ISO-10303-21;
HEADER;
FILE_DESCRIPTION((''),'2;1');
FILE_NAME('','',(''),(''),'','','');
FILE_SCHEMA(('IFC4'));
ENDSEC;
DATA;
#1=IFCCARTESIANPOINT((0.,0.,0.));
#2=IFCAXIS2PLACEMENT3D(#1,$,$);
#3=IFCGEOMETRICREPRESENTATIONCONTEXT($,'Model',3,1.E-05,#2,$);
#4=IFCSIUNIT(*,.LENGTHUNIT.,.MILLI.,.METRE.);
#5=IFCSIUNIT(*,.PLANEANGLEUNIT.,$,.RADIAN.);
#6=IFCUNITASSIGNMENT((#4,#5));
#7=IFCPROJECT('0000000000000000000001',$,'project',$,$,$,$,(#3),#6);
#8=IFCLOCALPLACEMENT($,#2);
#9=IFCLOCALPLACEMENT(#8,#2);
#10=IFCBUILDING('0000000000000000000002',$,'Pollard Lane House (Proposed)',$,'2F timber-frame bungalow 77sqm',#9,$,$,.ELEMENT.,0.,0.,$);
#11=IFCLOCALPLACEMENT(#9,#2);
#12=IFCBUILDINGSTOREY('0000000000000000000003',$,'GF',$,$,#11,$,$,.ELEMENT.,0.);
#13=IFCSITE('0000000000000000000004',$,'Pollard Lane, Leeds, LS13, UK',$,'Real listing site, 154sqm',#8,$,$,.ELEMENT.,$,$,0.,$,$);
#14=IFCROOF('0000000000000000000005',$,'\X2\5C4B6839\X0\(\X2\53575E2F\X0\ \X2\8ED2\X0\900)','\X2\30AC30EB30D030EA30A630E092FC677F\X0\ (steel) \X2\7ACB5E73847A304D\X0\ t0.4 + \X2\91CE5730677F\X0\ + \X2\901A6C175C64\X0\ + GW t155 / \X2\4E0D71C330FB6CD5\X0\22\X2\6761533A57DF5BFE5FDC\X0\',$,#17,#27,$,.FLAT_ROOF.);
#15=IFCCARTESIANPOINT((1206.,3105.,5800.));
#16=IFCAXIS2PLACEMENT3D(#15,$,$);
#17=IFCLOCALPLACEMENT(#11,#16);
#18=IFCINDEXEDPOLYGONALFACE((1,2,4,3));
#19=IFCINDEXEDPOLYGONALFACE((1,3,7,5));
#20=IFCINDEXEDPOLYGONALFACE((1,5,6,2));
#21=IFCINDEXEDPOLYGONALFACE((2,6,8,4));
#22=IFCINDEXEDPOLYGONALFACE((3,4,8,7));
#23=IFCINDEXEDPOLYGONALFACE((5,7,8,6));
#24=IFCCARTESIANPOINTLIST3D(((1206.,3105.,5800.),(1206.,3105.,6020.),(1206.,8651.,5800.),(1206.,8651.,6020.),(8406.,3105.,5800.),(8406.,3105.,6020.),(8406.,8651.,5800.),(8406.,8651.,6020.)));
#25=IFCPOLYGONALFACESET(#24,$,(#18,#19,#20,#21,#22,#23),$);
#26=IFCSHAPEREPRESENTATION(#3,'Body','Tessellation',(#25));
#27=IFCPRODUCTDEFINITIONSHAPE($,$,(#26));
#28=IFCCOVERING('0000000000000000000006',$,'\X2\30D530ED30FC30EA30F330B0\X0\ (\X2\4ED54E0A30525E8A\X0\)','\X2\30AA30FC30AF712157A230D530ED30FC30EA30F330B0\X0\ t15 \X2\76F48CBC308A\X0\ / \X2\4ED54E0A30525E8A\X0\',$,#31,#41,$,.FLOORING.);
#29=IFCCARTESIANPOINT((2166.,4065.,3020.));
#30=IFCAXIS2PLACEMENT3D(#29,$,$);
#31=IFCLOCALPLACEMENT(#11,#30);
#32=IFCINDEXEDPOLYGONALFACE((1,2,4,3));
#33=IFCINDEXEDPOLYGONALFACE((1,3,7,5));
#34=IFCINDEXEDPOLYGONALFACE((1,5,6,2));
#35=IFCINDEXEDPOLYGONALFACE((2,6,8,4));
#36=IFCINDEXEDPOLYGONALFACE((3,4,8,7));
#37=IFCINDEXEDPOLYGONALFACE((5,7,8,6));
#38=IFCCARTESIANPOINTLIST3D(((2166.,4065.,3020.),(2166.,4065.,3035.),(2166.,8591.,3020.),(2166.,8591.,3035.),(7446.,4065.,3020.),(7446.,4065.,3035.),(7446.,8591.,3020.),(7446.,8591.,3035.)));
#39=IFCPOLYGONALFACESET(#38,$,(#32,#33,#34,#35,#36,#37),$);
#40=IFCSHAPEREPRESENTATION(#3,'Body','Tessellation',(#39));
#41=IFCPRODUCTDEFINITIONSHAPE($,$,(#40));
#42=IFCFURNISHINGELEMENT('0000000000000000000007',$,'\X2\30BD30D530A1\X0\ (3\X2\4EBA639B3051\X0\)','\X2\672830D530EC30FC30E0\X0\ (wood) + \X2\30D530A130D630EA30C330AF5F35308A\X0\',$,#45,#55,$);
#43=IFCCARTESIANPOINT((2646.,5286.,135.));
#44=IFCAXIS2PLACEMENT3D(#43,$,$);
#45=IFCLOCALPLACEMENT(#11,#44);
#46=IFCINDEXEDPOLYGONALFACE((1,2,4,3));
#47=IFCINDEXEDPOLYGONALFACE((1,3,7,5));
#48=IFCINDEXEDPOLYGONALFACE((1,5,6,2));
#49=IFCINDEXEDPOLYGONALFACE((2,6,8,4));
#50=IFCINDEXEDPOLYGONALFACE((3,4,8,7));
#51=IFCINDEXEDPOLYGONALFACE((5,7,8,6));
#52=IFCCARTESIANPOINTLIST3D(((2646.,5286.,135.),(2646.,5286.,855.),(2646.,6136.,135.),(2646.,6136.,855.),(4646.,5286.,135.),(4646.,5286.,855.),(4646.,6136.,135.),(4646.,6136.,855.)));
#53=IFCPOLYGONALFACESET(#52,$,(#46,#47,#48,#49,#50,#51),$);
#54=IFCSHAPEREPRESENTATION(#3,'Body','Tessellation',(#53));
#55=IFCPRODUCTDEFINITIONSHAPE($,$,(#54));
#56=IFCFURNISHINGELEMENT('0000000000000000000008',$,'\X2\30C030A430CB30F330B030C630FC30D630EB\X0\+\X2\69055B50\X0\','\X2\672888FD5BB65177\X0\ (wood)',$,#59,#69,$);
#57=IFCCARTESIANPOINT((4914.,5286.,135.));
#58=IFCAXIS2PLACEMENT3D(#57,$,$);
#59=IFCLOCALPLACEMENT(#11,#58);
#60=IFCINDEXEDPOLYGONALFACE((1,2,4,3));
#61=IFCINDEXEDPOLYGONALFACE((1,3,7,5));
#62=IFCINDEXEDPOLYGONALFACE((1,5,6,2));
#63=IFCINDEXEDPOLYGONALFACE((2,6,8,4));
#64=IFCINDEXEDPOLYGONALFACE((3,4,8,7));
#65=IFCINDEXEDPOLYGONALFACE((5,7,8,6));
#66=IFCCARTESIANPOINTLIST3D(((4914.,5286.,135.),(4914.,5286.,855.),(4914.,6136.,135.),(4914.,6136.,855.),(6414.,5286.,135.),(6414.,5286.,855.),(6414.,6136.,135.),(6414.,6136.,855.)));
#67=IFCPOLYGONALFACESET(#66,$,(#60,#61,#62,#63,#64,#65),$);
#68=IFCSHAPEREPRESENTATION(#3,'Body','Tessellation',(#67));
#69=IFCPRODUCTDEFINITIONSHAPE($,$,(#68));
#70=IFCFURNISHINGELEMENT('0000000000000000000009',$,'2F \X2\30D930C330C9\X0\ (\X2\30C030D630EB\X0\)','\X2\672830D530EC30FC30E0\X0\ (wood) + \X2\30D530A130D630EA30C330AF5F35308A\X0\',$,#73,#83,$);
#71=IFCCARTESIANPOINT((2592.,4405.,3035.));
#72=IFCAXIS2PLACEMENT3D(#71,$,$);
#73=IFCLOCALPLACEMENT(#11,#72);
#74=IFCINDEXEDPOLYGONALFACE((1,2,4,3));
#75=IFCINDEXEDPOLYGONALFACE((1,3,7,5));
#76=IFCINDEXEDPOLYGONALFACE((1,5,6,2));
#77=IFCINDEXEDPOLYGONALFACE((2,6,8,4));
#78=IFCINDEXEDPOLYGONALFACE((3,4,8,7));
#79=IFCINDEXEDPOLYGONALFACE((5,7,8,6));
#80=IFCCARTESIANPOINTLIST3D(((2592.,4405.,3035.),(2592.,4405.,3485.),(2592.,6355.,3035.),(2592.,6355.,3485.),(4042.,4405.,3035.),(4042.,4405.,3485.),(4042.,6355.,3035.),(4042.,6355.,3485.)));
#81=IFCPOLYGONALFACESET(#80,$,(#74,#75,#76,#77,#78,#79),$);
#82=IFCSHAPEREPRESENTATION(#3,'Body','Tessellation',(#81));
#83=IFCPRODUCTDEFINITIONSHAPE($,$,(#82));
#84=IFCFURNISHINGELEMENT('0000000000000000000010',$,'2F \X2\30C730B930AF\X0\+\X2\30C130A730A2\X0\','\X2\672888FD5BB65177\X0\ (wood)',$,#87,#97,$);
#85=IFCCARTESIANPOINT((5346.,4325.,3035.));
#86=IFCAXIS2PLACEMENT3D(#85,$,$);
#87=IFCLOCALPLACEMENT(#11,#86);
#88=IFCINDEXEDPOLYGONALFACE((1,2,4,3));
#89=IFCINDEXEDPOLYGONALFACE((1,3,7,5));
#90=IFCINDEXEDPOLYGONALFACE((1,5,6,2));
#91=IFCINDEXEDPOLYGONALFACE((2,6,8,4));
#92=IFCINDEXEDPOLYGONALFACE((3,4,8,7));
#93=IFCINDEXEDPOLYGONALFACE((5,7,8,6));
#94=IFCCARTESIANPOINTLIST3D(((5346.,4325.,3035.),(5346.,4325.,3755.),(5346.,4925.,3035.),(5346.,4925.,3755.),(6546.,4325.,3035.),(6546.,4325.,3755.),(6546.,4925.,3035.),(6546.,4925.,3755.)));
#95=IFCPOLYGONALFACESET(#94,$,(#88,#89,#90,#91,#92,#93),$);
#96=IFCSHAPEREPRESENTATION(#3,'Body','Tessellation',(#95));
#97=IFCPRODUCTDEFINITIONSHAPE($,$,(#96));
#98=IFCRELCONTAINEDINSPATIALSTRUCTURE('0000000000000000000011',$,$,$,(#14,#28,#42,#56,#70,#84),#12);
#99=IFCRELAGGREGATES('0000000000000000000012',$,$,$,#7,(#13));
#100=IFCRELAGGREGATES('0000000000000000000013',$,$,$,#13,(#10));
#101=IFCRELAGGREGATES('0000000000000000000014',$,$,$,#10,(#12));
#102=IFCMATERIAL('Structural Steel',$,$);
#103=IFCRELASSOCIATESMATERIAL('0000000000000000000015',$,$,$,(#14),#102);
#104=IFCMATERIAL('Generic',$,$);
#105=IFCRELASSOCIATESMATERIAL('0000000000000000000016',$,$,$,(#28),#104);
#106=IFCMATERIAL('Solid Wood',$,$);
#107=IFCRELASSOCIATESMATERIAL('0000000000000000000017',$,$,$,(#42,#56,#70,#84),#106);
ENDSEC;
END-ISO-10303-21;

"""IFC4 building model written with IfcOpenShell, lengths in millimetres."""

from ifc_helpers import new_model, si_unit, frame, frame_2d, origin, place, context, project, spatial, rectangle, extrude, material, element, save


model = new_model("IFC4")

# Units and contexts
model_context = context("Model", 3, precision=1e-05, world=origin())
ifc_project = project(units=[si_unit("LENGTHUNIT", "METRE", prefix="MILLI"), si_unit("PLANEANGLEUNIT", "RADIAN")], contexts=[model_context])

# Site, building, storey
site_placement = place(None, origin())
site = spatial("IfcSite", under=ifc_project, at=site_placement, Name="Pollard Lane, Leeds, LS13, UK", ObjectType="Real listing site, 154sqm", CompositionType="ELEMENT", RefElevation=0.0)
building_placement = place(site_placement, origin())
building = spatial("IfcBuilding", under=site, at=building_placement, Name="Pollard Lane House (Proposed)", ObjectType="2F timber-frame bungalow 77sqm", CompositionType="ELEMENT", ElevationOfRefHeight=0.0, ElevationOfTerrain=0.0)
storey_placement = place(building_placement, origin())
storey = spatial("IfcBuildingStorey", under=building, at=storey_placement, Name="GF", CompositionType="ELEMENT", Elevation=0.0)

# Shared definitions
ifc_material_1 = material(Name="Solid Wood")

# Roof
ifc_material_2 = material(Name="Structural Steel")
for number, where, name in (
    (1, (1206.0, 3105.0, 5800.0), "屋根(南帯 軒900)"),
):
    element("IfcRoof", number, at=place(storey_placement, frame(where)), inside=storey, material=ifc_material_2, Name=name, Description="ガルバリウム鋼板 (steel) 立平葺き t0.4 + 野地板 + 通気層 + GW t155 / 不燃・法22条区域対応", PredefinedType="FLAT_ROOF", context=model_context, shape_type="SweptSolid", body=[
        extrude(rectangle(XDim=7200.0, YDim=5546.0, at=frame_2d((3600.0, 2773.0))), frame((1206.0, 3105.0, 5800.0)), (0.0, 0.0, 1.0), 220.0),
    ])

# Covering
ifc_material_3 = material(Name="Generic")
covering_placement = place(storey_placement, frame((2166.0, 4065.0, 3020.0)))
element("IfcCovering", 2, at=covering_placement, inside=storey, material=ifc_material_3, Name="フローリング (仕上げ床)", Description="オーク無垢フローリング t15 直貼り / 仕上げ床", PredefinedType="FLOORING", context=model_context, shape_type="SweptSolid", body=[
    extrude(rectangle(XDim=5280.0, YDim=4526.0, at=frame_2d((2640.0, 2263.0))), frame((2166.0, 4065.0, 3020.0)), (0.0, 0.0, 1.0), 15.0),
])

# Furnishing elements
furnishing_1_placement = place(storey_placement, frame((2646.0, 5286.0, 135.0)))
element("IfcFurnishingElement", 3, at=furnishing_1_placement, inside=storey, material=ifc_material_1, Name="ソファ (3人掛け)", Description="木フレーム (wood) + ファブリック張り", context=model_context, shape_type="SweptSolid", body=[
    extrude(rectangle(XDim=2000.0, YDim=850.0, at=frame_2d((1000.0, 425.0))), frame((2646.0, 5286.0, 135.0)), (0.0, 0.0, 1.0), 720.0),
])
furnishing_2_placement = place(storey_placement, frame((4914.0, 5286.0, 135.0)))
element("IfcFurnishingElement", 4, at=furnishing_2_placement, inside=storey, material=ifc_material_1, Name="ダイニングテーブル+椅子", Description="木製家具 (wood)", context=model_context, shape_type="SweptSolid", body=[
    extrude(rectangle(XDim=1500.0, YDim=850.0, at=frame_2d((750.0, 425.0))), frame((4914.0, 5286.0, 135.0)), (0.0, 0.0, 1.0), 720.0),
])
furnishing_3_placement = place(storey_placement, frame((2592.0, 4405.0, 3035.0)))
element("IfcFurnishingElement", 5, at=furnishing_3_placement, inside=storey, material=ifc_material_1, Name="2F ベッド (ダブル)", Description="木フレーム (wood) + ファブリック張り", context=model_context, shape_type="SweptSolid", body=[
    extrude(rectangle(XDim=1450.0, YDim=1950.0, at=frame_2d((725.0, 975.0))), frame((2592.0, 4405.0, 3035.0)), (0.0, 0.0, 1.0), 450.0),
])
furnishing_4_placement = place(storey_placement, frame((5346.0, 4325.0, 3035.0)))
element("IfcFurnishingElement", 6, at=furnishing_4_placement, inside=storey, material=ifc_material_1, Name="2F デスク+チェア", Description="木製家具 (wood)", context=model_context, shape_type="SweptSolid", body=[
    extrude(rectangle(XDim=1200.0, YDim=600.0, at=frame_2d((600.0, 300.0))), frame((5346.0, 4325.0, 3035.0)), (0.0, 0.0, 1.0), 720.0),
])

save(model, "model.ifc")
